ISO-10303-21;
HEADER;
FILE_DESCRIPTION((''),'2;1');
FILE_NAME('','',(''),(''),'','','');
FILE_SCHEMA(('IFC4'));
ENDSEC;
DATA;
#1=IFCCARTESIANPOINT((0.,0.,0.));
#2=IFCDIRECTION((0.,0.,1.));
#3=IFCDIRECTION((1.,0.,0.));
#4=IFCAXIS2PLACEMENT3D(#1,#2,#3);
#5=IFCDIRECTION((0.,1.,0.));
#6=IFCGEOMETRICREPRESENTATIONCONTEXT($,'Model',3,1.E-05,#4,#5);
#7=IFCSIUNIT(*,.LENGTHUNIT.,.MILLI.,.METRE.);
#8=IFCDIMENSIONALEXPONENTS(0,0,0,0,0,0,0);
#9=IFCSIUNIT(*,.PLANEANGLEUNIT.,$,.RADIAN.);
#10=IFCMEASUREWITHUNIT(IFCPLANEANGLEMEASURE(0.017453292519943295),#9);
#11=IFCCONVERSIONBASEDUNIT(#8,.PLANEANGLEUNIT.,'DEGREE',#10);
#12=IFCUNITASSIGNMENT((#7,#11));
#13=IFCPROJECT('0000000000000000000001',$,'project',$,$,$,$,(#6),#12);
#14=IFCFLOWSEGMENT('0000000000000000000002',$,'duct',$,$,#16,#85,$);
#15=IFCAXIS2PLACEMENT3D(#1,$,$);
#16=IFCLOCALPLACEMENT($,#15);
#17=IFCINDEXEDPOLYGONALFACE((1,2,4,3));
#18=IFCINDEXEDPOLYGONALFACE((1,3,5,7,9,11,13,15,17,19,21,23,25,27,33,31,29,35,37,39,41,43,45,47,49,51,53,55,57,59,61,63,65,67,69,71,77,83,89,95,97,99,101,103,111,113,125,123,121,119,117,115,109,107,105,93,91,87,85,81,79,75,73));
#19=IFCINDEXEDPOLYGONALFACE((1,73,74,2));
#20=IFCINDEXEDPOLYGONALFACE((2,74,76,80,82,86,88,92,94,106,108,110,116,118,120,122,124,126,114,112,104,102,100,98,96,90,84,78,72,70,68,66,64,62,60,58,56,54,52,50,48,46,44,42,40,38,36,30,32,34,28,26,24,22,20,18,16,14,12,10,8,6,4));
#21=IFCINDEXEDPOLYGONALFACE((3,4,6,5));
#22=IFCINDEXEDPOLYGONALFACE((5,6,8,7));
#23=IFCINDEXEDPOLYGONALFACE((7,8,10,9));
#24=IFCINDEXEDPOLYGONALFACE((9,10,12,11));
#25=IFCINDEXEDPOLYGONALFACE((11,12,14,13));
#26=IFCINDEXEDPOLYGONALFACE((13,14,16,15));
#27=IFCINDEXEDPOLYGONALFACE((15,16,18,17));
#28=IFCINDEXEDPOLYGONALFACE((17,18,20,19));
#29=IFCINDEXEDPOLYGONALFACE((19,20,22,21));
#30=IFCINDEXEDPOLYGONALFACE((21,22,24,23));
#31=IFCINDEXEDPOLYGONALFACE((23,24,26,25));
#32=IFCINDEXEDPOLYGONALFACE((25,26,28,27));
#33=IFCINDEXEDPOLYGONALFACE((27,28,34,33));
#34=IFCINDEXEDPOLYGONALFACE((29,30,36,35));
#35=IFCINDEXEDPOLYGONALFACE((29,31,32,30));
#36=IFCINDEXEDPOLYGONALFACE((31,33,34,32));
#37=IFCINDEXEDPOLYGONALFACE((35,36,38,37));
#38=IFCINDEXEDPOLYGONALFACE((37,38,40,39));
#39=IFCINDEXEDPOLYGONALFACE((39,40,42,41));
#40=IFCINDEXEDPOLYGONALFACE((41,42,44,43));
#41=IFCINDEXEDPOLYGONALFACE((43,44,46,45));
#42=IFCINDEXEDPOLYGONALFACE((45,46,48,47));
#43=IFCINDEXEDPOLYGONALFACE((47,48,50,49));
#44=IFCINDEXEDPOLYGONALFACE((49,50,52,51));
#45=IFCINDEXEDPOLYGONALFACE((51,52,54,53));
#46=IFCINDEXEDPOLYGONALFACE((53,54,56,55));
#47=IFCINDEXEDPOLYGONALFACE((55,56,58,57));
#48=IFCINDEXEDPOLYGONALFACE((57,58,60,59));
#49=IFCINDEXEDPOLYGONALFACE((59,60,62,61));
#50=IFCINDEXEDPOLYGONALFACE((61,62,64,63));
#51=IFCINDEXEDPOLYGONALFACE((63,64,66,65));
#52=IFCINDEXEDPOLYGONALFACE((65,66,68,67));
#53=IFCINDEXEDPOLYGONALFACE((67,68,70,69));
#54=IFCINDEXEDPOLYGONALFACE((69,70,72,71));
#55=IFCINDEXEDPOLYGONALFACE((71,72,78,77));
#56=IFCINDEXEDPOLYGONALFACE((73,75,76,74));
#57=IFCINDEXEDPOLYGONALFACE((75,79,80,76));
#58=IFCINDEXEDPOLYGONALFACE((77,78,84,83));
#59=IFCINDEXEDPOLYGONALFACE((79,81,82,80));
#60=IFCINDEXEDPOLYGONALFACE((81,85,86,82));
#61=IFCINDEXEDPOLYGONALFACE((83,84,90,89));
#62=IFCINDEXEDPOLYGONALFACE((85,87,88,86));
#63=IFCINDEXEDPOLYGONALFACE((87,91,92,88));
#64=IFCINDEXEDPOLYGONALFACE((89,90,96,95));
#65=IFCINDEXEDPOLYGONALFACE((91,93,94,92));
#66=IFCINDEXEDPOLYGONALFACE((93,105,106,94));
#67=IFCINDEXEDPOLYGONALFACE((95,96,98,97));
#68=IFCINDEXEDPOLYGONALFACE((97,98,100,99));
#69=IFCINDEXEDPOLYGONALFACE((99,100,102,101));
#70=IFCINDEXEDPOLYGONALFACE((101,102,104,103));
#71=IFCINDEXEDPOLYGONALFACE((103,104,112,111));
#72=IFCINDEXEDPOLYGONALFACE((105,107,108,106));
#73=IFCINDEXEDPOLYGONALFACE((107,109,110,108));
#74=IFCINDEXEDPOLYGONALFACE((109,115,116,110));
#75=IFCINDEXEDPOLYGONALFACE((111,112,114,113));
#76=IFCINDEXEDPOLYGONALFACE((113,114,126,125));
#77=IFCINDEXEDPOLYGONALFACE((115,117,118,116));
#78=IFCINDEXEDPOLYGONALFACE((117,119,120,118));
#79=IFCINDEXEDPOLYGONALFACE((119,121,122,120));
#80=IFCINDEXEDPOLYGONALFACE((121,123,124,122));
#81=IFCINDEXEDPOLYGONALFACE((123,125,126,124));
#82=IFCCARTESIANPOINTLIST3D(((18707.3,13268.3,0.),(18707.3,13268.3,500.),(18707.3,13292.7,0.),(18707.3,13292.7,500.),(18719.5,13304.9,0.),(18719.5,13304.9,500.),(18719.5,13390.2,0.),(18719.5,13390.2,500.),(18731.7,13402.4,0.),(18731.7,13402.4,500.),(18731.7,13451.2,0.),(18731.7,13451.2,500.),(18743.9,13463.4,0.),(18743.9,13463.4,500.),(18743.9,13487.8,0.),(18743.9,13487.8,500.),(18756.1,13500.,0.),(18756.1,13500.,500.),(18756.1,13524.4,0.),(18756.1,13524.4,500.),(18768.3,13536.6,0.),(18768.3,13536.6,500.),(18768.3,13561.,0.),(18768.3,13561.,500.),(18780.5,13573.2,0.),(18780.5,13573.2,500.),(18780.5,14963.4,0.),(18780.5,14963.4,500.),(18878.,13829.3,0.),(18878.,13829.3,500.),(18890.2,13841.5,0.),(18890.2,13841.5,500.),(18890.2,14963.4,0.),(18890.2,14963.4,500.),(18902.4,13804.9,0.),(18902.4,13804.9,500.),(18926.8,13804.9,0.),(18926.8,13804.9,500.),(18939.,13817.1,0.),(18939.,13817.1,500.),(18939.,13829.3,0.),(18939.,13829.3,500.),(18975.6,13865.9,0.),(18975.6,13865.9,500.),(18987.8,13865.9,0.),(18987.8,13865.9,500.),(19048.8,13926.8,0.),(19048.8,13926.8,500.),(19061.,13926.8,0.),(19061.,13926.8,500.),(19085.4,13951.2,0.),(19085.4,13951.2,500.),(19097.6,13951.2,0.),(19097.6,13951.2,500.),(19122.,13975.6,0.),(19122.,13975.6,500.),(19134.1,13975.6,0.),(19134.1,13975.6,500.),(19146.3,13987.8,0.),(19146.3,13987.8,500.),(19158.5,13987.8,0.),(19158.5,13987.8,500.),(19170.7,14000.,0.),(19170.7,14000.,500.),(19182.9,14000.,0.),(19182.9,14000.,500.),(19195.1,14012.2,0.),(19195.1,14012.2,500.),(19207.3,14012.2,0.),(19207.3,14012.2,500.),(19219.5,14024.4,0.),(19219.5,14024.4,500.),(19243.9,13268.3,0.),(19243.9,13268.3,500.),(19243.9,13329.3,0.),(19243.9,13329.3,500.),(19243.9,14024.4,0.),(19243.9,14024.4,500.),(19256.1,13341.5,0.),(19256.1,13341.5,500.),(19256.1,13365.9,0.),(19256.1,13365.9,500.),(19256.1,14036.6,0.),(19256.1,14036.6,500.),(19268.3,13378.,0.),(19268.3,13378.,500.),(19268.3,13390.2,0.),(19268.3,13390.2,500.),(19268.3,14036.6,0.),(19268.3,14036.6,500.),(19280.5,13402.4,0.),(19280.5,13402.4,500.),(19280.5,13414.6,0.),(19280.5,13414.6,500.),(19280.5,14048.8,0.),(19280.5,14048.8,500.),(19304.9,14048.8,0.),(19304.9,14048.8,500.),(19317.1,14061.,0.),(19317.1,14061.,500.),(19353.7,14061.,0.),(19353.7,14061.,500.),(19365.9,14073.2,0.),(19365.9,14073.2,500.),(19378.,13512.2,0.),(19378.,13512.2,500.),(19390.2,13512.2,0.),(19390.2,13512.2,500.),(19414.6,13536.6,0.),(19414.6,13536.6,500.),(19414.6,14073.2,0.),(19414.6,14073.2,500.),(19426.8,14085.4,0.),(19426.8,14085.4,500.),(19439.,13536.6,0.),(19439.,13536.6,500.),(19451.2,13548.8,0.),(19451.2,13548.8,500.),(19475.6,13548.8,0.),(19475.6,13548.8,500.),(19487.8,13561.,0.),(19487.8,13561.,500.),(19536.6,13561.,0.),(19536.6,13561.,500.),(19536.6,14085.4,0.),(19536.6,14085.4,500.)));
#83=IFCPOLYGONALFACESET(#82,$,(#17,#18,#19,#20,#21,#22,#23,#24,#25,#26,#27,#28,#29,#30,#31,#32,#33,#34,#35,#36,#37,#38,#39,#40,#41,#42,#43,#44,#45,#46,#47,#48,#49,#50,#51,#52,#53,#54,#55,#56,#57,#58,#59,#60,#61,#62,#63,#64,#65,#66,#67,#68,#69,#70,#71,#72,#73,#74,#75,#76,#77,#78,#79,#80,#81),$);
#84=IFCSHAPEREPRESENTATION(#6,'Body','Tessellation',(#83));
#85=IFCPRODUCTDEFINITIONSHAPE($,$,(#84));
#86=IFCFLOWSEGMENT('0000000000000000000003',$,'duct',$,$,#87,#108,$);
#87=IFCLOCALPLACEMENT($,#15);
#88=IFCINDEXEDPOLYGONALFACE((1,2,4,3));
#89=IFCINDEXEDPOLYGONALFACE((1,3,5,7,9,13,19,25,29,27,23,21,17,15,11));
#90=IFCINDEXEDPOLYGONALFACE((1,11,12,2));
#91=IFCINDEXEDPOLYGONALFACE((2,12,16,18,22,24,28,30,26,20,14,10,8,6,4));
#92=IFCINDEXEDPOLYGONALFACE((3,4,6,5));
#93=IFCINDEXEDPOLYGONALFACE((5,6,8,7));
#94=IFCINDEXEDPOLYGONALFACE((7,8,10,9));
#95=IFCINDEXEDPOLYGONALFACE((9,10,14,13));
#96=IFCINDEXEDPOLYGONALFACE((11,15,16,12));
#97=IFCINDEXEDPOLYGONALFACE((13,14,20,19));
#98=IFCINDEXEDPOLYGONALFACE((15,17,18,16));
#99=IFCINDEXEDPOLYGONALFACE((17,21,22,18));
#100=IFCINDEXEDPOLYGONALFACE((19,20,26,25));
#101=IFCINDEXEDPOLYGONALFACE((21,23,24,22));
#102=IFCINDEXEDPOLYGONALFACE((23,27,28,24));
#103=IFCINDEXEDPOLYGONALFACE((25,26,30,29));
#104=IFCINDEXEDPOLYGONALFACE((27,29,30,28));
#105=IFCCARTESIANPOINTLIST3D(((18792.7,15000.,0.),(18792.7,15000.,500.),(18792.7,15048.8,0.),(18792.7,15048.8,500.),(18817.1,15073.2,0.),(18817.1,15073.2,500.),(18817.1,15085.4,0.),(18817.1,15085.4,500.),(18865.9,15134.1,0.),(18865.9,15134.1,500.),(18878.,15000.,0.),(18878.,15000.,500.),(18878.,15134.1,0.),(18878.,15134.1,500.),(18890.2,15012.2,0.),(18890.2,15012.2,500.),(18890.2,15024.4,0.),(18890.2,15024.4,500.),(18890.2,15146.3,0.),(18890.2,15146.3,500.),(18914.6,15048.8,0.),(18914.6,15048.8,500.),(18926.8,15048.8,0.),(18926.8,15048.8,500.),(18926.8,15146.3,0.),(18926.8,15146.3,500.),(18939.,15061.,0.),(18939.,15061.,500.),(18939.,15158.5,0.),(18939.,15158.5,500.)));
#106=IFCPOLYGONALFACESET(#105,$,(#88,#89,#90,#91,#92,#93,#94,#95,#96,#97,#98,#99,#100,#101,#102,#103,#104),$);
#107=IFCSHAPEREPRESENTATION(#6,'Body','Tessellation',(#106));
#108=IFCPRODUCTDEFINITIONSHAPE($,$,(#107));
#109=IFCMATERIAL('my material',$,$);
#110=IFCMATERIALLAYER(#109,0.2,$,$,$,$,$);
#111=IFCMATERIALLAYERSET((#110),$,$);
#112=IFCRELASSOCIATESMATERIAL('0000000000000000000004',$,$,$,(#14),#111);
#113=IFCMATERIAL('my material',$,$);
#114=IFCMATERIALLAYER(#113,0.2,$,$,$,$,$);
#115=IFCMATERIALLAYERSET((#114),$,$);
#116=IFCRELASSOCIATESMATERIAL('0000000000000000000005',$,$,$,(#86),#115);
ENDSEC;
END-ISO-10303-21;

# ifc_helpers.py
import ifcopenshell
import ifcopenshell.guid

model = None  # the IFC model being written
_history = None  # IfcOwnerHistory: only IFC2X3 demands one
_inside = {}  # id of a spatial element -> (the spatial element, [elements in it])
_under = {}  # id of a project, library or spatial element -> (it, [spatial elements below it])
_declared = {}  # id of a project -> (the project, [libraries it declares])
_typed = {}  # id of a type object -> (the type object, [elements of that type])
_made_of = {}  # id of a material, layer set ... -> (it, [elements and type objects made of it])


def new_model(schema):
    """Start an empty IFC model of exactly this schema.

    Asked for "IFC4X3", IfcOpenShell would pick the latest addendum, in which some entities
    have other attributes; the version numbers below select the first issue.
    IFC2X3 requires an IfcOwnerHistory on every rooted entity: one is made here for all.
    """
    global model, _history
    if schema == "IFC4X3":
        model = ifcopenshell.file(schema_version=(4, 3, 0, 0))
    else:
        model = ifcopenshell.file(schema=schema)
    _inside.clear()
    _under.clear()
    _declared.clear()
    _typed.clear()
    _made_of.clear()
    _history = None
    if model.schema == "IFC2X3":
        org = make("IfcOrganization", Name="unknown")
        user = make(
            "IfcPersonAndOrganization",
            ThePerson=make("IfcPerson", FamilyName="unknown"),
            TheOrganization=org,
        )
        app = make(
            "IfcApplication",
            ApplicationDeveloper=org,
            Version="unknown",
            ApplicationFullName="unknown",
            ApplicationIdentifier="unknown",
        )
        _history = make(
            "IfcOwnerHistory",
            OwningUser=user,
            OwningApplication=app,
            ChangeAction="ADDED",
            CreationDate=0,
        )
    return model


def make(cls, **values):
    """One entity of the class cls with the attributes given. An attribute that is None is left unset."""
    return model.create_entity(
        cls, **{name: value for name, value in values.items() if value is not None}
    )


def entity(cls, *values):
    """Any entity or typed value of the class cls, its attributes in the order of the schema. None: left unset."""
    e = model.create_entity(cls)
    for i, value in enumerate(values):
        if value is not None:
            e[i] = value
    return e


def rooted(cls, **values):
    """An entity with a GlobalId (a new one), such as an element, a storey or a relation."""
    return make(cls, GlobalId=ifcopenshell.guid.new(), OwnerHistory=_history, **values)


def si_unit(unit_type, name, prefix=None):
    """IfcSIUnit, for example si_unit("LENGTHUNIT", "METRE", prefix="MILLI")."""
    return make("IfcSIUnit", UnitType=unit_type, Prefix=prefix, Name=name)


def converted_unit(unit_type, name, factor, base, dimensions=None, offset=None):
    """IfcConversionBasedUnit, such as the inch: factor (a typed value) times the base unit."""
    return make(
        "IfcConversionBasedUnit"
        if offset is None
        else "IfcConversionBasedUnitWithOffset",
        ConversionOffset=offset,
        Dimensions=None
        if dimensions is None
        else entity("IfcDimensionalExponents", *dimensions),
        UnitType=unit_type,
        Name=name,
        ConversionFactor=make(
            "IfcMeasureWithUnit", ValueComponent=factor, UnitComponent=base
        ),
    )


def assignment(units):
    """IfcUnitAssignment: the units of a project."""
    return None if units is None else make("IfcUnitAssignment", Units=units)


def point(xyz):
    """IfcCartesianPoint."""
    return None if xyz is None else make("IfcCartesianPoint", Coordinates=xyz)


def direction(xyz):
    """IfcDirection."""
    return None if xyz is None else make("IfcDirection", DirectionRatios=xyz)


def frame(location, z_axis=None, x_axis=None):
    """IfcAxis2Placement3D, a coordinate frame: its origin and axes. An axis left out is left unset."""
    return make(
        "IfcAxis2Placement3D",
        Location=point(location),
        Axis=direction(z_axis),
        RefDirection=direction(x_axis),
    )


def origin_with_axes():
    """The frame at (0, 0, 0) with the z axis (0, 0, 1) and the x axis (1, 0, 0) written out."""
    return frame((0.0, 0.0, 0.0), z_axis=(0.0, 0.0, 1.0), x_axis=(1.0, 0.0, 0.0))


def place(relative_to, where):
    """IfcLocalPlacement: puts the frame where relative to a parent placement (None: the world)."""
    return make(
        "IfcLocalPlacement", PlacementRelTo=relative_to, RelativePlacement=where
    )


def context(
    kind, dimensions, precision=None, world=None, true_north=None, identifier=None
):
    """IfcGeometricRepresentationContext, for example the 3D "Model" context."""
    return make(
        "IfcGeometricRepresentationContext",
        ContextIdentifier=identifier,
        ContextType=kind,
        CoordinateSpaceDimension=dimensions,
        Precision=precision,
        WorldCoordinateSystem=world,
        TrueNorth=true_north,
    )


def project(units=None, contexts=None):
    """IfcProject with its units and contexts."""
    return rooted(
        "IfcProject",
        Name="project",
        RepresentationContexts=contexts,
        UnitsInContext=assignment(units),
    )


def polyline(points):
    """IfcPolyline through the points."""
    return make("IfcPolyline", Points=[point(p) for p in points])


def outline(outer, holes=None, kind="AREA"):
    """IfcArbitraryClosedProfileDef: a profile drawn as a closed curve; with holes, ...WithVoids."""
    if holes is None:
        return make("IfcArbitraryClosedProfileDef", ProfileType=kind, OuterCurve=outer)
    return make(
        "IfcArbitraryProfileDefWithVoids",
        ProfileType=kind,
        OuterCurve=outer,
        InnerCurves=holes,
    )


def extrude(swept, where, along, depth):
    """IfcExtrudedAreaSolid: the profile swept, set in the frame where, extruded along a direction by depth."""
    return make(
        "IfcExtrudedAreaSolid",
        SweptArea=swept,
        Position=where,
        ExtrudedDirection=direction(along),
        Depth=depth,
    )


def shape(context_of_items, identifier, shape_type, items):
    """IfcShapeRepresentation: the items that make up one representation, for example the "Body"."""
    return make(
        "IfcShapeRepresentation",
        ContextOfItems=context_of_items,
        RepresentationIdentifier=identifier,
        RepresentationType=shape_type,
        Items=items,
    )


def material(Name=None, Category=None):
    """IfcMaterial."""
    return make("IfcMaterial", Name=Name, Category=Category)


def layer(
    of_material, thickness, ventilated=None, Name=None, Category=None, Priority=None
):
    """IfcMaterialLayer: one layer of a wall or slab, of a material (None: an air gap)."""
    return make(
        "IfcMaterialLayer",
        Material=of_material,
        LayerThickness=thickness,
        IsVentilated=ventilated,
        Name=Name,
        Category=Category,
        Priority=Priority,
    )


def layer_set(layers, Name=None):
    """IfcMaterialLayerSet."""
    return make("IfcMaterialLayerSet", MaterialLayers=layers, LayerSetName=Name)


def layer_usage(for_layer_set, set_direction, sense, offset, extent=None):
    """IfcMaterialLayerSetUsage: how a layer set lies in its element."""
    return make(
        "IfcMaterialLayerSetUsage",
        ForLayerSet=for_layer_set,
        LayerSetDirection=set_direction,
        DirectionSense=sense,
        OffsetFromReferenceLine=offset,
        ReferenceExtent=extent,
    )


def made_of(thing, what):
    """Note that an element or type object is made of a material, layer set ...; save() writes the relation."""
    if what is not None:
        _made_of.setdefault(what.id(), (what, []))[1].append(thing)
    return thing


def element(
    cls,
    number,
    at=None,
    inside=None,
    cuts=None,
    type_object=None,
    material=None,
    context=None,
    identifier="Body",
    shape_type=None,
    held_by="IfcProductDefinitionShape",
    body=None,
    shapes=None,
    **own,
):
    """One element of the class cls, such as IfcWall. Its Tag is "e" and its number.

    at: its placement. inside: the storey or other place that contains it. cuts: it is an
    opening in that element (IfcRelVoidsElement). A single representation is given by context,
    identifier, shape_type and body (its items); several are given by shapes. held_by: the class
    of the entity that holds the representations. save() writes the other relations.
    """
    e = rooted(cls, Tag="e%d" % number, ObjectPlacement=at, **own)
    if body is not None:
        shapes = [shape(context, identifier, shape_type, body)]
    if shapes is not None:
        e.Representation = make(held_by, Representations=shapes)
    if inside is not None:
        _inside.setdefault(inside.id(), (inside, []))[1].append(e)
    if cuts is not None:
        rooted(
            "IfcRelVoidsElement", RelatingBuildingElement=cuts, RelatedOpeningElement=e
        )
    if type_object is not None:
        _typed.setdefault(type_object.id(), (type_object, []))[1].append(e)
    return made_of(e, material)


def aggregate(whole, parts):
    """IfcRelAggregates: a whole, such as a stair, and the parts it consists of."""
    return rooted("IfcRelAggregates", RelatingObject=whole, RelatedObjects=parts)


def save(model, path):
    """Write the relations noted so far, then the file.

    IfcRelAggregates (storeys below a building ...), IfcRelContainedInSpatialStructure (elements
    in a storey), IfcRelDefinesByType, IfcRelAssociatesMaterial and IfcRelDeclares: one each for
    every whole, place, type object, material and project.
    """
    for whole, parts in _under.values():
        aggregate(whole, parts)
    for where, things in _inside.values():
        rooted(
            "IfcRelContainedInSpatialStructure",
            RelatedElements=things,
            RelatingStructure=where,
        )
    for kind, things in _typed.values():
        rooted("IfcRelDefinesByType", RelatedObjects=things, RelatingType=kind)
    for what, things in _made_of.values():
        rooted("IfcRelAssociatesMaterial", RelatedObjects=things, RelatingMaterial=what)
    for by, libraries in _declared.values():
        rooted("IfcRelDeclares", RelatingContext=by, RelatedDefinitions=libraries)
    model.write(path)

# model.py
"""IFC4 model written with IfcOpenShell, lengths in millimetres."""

from ifc_helpers import new_model, entity, si_unit, converted_unit, direction, origin_with_axes, place, context, project, polyline, outline, extrude, material, layer, layer_set, layer_usage, element, save


model = new_model("IFC4")

# Units and contexts
model_context = context("Model", 3, precision=1e-05, world=origin_with_axes(), true_north=direction((0.0, 1.0, 0.0)))
ifc_project = project(units=[si_unit("LENGTHUNIT", "METRE", prefix="MILLI"), converted_unit("PLANEANGLEUNIT", "DEGREE", entity("IfcPlaneAngleMeasure", 0.017453292519943295), si_unit("PLANEANGLEUNIT", "RADIAN"), dimensions=[0, 0, 0, 0, 0, 0, 0])], contexts=[model_context])

# Flow segments
ifc_material_1 = material(Name="my material")
ifc_layer_1 = layer(ifc_material_1, 0.2)
ifc_layer_set_1 = layer_set([ifc_layer_1])
ifc_layer_usage_1 = layer_usage(ifc_layer_set_1, "AXIS2", "POSITIVE", -0.1)
flow_segment_1_placement = place(None, origin_with_axes())
element("IfcFlowSegment", 1, at=flow_segment_1_placement, material=ifc_layer_usage_1, Name="duct", context=model_context, shape_type="SweptSolid", body=[
    extrude(outline(polyline([(18707.3, 13268.3), (19243.9, 13268.3), (19243.9, 13329.3), (19256.1, 13341.5), (19256.1, 13365.9), (19268.3, 13378.0), (19268.3, 13390.2), (19280.5, 13402.4), (19280.5, 13414.6), (19378.0, 13512.2), (19390.2, 13512.2), (19414.6, 13536.6), (19439.0, 13536.6), (19451.2, 13548.8), (19475.6, 13548.8), (19487.8, 13561.0), (19536.6, 13561.0), (19536.6, 14085.4), (19426.8, 14085.4), (19414.6, 14073.2), (19365.9, 14073.2), (19353.7, 14061.0), (19317.1, 14061.0), (19304.9, 14048.8), (19280.5, 14048.8), (19268.3, 14036.6), (19256.1, 14036.6), (19243.9, 14024.4), (19219.5, 14024.4), (19207.3, 14012.2), (19195.1, 14012.2), (19182.9, 14000.0), (19170.7, 14000.0), (19158.5, 13987.8), (19146.3, 13987.8), (19134.1, 13975.6), (19122.0, 13975.6), (19097.6, 13951.2), (19085.4, 13951.2), (19061.0, 13926.8), (19048.8, 13926.8), (18987.8, 13865.9), (18975.6, 13865.9), (18939.0, 13829.3), (18939.0, 13817.1), (18926.8, 13804.9), (18902.4, 13804.9), (18878.0, 13829.3), (18890.2, 13841.5), (18890.2, 14963.4), (18780.5, 14963.4), (18780.5, 13573.2), (18768.3, 13561.0), (18768.3, 13536.6), (18756.1, 13524.4), (18756.1, 13500.0), (18743.9, 13487.8), (18743.9, 13463.4), (18731.7, 13451.2), (18731.7, 13402.4), (18719.5, 13390.2), (18719.5, 13304.9), (18707.3, 13292.7), (18707.3, 13268.3)])), origin_with_axes(), (0.0, 0.0, 1.0), 500.0),
])
ifc_material_2 = material(Name="my material")
ifc_layer_2 = layer(ifc_material_2, 0.2)
ifc_layer_set_2 = layer_set([ifc_layer_2])
ifc_layer_usage_2 = layer_usage(ifc_layer_set_2, "AXIS2", "POSITIVE", -0.1)
flow_segment_2_placement = place(None, origin_with_axes())
element("IfcFlowSegment", 2, at=flow_segment_2_placement, material=ifc_layer_usage_2, Name="duct", context=model_context, shape_type="SweptSolid", body=[
    extrude(outline(polyline([(18792.7, 15000.0), (18878.0, 15000.0), (18890.2, 15012.2), (18890.2, 15024.4), (18914.6, 15048.8), (18926.8, 15048.8), (18939.0, 15061.0), (18939.0, 15158.5), (18926.8, 15146.3), (18890.2, 15146.3), (18878.0, 15134.1), (18865.9, 15134.1), (18817.1, 15085.4), (18817.1, 15073.2), (18792.7, 15048.8), (18792.7, 15000.0)])), origin_with_axes(), (0.0, 0.0, 1.0), 500.0),
])

save(model, "model.ifc")
